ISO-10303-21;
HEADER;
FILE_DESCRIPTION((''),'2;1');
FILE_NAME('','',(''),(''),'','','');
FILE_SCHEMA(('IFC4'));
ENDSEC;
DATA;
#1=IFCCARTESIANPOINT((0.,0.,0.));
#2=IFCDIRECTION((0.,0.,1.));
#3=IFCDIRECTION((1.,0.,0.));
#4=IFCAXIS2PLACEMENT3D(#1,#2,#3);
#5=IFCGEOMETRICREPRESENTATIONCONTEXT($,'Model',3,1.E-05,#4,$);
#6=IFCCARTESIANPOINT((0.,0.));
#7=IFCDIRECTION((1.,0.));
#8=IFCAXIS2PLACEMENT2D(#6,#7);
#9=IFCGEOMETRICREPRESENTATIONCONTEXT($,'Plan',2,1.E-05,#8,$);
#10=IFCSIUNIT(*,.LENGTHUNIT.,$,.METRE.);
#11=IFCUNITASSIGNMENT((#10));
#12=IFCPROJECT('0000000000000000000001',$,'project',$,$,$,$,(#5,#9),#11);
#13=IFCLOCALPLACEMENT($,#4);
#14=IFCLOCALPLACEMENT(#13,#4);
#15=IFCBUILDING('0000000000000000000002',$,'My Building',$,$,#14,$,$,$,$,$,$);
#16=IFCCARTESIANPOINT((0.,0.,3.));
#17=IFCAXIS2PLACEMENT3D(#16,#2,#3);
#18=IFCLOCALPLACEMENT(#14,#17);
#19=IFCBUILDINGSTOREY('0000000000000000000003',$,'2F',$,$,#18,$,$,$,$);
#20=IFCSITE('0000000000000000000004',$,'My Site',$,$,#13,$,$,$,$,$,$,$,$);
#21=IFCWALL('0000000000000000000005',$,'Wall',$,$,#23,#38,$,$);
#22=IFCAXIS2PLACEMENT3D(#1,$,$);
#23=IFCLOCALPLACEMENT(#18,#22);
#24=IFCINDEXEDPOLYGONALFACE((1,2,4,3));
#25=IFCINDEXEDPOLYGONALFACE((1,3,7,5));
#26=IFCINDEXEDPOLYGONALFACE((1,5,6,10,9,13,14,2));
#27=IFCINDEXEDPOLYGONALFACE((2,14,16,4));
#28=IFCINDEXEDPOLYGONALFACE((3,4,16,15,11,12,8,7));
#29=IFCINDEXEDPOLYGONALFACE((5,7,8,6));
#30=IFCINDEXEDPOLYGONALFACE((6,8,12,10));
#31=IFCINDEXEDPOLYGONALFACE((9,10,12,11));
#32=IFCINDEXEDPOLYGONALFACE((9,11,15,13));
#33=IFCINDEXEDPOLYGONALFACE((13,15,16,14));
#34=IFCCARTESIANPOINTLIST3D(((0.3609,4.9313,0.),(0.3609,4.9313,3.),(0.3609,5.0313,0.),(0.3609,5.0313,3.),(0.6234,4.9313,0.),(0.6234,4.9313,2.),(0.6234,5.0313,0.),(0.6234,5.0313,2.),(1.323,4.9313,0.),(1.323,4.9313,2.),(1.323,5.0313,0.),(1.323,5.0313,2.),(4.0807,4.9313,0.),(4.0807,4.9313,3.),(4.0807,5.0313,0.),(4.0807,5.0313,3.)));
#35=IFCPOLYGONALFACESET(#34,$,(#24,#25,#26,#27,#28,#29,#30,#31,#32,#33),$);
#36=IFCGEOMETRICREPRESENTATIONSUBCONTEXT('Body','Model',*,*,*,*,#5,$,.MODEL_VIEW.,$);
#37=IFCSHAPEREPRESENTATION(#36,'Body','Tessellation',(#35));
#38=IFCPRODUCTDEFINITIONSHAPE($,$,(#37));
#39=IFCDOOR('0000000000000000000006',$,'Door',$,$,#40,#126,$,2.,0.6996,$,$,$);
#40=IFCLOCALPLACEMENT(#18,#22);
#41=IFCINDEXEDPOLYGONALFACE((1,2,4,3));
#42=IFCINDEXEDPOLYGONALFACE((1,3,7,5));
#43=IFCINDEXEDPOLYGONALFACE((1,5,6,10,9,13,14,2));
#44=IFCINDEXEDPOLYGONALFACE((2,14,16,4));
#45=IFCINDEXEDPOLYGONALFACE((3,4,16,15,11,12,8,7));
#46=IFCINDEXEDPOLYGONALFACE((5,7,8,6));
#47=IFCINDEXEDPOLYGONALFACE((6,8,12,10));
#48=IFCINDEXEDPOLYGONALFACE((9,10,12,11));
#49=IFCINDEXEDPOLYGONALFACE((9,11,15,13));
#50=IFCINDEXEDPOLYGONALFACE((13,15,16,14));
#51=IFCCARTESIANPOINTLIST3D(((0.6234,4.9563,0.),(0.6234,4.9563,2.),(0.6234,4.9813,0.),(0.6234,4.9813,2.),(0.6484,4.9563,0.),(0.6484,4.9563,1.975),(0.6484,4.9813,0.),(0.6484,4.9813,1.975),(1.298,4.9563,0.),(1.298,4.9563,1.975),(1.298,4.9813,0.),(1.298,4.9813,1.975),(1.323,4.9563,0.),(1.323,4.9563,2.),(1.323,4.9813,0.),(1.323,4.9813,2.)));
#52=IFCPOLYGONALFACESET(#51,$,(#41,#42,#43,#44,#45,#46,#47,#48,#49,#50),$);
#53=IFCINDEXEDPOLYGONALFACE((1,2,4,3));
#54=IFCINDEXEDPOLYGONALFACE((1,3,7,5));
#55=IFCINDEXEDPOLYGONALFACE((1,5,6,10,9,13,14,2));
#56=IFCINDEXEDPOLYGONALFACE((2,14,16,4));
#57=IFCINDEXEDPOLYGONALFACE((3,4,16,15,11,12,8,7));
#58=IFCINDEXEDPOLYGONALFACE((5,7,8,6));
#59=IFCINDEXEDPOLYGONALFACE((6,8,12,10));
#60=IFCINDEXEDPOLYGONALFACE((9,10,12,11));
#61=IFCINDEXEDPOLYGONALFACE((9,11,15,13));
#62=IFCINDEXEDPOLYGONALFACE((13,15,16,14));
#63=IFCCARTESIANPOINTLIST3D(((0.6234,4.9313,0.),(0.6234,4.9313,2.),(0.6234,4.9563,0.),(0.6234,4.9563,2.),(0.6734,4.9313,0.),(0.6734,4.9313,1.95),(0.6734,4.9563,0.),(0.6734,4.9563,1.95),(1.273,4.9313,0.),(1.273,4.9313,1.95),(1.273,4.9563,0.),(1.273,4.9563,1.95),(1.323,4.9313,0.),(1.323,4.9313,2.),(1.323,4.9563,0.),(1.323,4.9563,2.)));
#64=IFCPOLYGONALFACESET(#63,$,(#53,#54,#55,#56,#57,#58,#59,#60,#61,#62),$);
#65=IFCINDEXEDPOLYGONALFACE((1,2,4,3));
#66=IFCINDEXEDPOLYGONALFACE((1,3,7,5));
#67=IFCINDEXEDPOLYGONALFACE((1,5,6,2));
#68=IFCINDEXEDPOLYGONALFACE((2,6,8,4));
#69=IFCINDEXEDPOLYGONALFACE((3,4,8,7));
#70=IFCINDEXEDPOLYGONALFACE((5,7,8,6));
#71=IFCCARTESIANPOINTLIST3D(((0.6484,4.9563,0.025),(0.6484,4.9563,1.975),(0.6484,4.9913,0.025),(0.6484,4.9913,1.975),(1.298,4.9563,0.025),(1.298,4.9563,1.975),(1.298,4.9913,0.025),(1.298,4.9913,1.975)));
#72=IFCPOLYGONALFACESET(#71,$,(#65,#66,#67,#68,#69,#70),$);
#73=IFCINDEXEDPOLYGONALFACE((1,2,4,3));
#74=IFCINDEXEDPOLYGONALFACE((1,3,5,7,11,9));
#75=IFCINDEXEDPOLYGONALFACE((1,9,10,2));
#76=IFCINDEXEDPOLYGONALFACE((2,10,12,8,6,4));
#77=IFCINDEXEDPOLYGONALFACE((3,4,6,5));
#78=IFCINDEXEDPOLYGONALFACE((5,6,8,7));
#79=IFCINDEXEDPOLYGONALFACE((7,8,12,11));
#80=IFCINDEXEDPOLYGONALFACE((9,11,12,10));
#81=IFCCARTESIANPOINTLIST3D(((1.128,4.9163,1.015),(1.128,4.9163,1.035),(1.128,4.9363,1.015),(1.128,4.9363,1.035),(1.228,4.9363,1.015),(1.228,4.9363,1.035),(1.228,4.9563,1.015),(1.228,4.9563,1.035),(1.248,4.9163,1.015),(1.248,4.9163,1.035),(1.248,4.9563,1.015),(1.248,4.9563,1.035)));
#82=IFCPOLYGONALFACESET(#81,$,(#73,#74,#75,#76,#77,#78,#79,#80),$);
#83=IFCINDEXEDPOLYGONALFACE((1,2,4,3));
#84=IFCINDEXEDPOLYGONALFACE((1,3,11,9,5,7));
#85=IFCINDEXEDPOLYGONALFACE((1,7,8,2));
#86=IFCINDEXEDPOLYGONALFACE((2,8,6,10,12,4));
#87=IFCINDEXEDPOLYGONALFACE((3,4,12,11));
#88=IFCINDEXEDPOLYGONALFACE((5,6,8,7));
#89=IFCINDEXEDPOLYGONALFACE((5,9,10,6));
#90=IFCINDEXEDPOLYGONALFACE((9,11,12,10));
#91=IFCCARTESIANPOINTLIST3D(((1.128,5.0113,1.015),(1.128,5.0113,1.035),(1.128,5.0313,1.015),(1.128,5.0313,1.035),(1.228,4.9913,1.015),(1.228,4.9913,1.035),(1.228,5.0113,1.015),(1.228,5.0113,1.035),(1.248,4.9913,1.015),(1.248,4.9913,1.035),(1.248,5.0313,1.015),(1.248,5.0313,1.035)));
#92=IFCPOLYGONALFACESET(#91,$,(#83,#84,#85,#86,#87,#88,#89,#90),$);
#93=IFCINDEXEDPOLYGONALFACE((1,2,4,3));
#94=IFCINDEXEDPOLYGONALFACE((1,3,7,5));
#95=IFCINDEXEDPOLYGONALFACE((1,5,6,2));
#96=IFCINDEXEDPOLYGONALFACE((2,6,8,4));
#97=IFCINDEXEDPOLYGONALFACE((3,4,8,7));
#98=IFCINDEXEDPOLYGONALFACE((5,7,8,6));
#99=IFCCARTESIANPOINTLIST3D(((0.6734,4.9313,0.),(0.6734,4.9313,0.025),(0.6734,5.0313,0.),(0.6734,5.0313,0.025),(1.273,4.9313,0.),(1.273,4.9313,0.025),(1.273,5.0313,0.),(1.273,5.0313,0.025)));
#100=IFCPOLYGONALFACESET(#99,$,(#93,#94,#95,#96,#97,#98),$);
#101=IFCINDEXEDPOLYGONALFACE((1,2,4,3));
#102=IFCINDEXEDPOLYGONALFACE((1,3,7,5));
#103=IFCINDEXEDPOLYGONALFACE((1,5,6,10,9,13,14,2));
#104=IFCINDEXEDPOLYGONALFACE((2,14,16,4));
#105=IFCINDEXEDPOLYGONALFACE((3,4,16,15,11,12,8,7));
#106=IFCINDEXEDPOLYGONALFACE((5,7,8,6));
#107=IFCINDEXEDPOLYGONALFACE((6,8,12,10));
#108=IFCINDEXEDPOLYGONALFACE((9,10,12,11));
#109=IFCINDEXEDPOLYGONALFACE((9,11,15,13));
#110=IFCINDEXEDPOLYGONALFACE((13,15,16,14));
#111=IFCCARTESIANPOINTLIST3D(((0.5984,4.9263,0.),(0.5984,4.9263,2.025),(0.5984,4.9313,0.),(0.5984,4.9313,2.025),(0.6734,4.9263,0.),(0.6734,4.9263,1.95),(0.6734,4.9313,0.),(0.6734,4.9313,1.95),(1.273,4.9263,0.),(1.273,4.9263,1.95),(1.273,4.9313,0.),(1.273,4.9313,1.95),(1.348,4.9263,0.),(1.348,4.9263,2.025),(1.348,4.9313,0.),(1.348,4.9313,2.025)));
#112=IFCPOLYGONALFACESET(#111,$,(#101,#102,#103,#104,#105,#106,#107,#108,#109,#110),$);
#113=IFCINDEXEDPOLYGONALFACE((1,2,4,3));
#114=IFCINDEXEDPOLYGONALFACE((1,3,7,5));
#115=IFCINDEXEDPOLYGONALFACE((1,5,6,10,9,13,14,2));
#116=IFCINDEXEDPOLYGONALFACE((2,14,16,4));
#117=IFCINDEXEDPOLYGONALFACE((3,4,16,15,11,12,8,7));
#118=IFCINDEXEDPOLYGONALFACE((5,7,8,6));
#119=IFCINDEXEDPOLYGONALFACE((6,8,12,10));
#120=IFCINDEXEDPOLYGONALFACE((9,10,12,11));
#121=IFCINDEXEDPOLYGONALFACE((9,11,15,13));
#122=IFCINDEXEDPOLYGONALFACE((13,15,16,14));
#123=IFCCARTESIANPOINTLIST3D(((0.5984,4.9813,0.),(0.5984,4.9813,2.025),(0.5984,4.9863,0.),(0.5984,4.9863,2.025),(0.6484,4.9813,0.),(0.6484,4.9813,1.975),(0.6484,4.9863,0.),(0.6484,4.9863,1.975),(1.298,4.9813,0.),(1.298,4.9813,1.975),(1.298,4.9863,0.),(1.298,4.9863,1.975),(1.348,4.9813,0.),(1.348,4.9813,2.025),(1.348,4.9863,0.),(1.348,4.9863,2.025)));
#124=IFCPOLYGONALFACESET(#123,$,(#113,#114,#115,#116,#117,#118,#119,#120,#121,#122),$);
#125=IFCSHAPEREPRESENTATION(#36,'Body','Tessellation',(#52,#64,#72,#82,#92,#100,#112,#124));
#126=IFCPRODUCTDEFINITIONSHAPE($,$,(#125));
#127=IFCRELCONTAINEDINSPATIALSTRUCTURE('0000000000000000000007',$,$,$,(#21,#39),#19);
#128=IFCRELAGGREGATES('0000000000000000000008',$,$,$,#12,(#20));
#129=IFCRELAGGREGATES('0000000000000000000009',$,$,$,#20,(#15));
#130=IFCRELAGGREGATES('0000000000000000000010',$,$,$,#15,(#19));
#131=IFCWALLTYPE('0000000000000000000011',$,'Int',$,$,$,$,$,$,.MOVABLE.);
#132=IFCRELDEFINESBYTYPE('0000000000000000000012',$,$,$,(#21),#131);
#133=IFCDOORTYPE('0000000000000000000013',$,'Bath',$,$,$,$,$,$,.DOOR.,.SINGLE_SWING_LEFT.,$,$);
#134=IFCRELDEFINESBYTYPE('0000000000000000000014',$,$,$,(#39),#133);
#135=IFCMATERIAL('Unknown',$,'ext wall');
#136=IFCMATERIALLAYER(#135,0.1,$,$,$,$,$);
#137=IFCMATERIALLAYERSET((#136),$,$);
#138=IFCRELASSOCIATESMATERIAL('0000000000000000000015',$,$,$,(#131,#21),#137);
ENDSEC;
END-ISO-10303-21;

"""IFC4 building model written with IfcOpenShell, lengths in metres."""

from ifc_helpers import new_model, entity, si_unit, frame, origin_with_axes, origin_2d_with_axis, place, context, subcontext, project, spatial, line, indexed_curve, outline, extrude, shape, source, transform, mapped, material, layer, layer_set, layer_usage, type_object, type_shapes, element, fill, save


model = new_model("IFC4")

# Units and contexts
model_context = context("Model", 3, precision=1e-05, world=origin_with_axes())
plan_context = context("Plan", 2, precision=1e-05, world=origin_2d_with_axis())
body_context_1 = subcontext(model_context, "Body", "Model", "MODEL_VIEW")
body_context_2 = subcontext(plan_context, "Body", "Plan", "PLAN_VIEW")
ifc_project = project(units=[si_unit("LENGTHUNIT", "METRE")], contexts=[model_context, plan_context])

# Site, building, storey
site_placement = place(None, origin_with_axes())
site = spatial("IfcSite", under=ifc_project, at=site_placement, Name="My Site")
building_placement = place(site_placement, origin_with_axes())
building = spatial("IfcBuilding", under=site, at=building_placement, Name="My Building")
storey_placement = place(building_placement, frame((0.0, 0.0, 3.0), z_axis=(0.0, 0.0, 1.0), x_axis=(1.0, 0.0, 0.0)))
storey = spatial("IfcBuildingStorey", under=building, at=storey_placement, Name="2F")

# Shared definitions
ifc_material = material(Name="Unknown", Category="ext wall")

# Wall, opening, door
ifc_layer_1 = layer(ifc_material, 0.1)
ifc_layer_set_1 = layer_set([ifc_layer_1])
wall_type_1 = type_object("IfcWallType", Name="Int", PredefinedType="MOVABLE", material=ifc_layer_set_1)
ifc_layer_usage_1 = layer_usage(ifc_layer_set_1, "AXIS2", "POSITIVE", 0.0)
wall_1_placement = place(storey_placement, frame((4.0807, 5.0313, 0.0), z_axis=(0.0, 0.0, 1.0), x_axis=(-1.0, 0.0, 0.0)))
wall_1 = element("IfcWall", 1, at=wall_1_placement, inside=storey, type_object=wall_type_1, material=ifc_layer_usage_1, Name="Wall", context=body_context_1, shape_type="SweptSolid", body=[
    extrude(outline(indexed_curve([(0.0, 0.0), (0.0, 0.1), (3.7198, 0.1), (3.7198, 0.0)], segments=[line(1, 2, 3, 4, 1)])), origin_with_axes(), (0.0, 0.0, 1.0), 3.0),
])
shared_shape_1 = source(origin_with_axes(), body_context_1, "Body", "SweptSolid", [
    extrude(outline(indexed_curve([(0.0, 0.0), (0.6996, 0.0), (0.6996, 2.0), (0.0, 2.0)], segments=[line(1, 2, 3, 4, 1)])), frame((0.0, -0.6, 0.0), z_axis=(0.0, -1.0, 0.0), x_axis=(1.0, 0.0, 0.0)), (0.0, 0.0, -1.0), 1.2),
])
opening_1_placement = place(wall_1_placement, frame((3.4573, 0.1, 0.0), z_axis=(0.0, 0.0, 1.0), x_axis=(-1.0, 0.0, 0.0)))
opening_1 = element("IfcOpeningElement", 2, at=opening_1_placement, cuts=wall_1, PredefinedType="OPENING", context=body_context_1, shape_type="MappedRepresentation", body=[
    mapped(shared_shape_1, transform((0.0, 0.0, 0.0), x_axis=(1.0, 0.0, 0.0), y_axis=(0.0, 1.0, 0.0), z_axis=(0.0, 0.0, 1.0), scale=1.0)),
])
door_type_1 = type_object("IfcDoorType", Name="Bath", OperationType="SINGLE_SWING_LEFT", PredefinedType="DOOR")
shared_shape_2 = source(origin_with_axes(), body_context_1, "Body", "SweptSolid", [
    extrude(outline(indexed_curve([(0.0, 0.0), (0.0, 2.0), (0.6996, 2.0), (0.6996, 0.0), (0.6746, 0.0), (0.6746, 1.975), (0.025, 1.975), (0.025, 0.0)], segments=[line(1, 2, 3, 4, 5, 6, 7, 8, 1)])), frame((0.0, 0.025, 0.0), z_axis=(0.0, -1.0, 0.0), x_axis=(1.0, 0.0, 0.0)), (0.0, 0.0, -1.0), 0.025),
    extrude(outline(indexed_curve([(0.0, 0.0), (0.0, 2.0), (0.6996, 2.0), (0.6996, 0.0), (0.6496, 0.0), (0.6496, 1.95), (0.05, 1.95), (0.05, 0.0)], segments=[line(1, 2, 3, 4, 5, 6, 7, 8, 1)])), frame((0.0, 0.0, 0.0), z_axis=(0.0, -1.0, 0.0), x_axis=(1.0, 0.0, 0.0)), (0.0, 0.0, -1.0), 0.025),
    extrude(outline(indexed_curve([(0.0, 0.0), (0.6496, 0.0), (0.6496, 0.035), (0.0, 0.035)], segments=[line(1, 2, 3, 4, 1)])), frame((0.025, 0.025, 0.025), z_axis=(0.0, 0.0, 1.0), x_axis=(1.0, 0.0, 0.0)), (0.0, 0.0, 1.0), 1.95),
    extrude(outline(indexed_curve([(0.0, 0.0), (0.0, -0.04), (-0.12, -0.04), (-0.12, -0.02), (-0.02, -0.02), (-0.02, 0.0)], segments=[line(1, 2, 3, 4, 5, 6, 1)])), frame((0.6246, 0.025, 1.015), z_axis=(0.0, 0.0, 1.0), x_axis=(1.0, 0.0, 0.0)), (0.0, 0.0, 1.0), 0.02),
    extrude(outline(indexed_curve([(0.0, 0.0), (0.0, 0.04), (-0.12, 0.04), (-0.12, 0.02), (-0.02, 0.02), (-0.02, 0.0)], segments=[line(1, 2, 3, 4, 5, 6, 1)])), frame((0.6246, 0.06, 1.015), z_axis=(0.0, 0.0, 1.0), x_axis=(1.0, 0.0, 0.0)), (0.0, 0.0, 1.0), 0.02),
    extrude(outline(indexed_curve([(0.0, 0.0), (0.5996, 0.0), (0.5996, 0.1), (0.0, 0.1)], segments=[line(1, 2, 3, 4, 1)])), frame((0.05, 0.0, 0.0), z_axis=(0.0, 0.0, 1.0), x_axis=(1.0, 0.0, 0.0)), (0.0, 0.0, 1.0), 0.025),
    extrude(outline(indexed_curve([(0.0, 0.0), (0.0, 2.025), (0.7496, 2.025), (0.7496, 0.0), (0.6746, 0.0), (0.6746, 1.95), (0.075, 1.95), (0.075, 0.0)], segments=[line(1, 2, 3, 4, 5, 6, 7, 8, 1)])), frame((-0.025, -0.005, 0.0), z_axis=(0.0, -1.0, 0.0), x_axis=(1.0, 0.0, 0.0)), (0.0, 0.0, -1.0), 0.005),
    extrude(outline(indexed_curve([(0.0, 0.0), (0.0, 2.025), (0.7496, 2.025), (0.7496, 0.0), (0.6996, 0.0), (0.6996, 1.975), (0.05, 1.975), (0.05, 0.0)], segments=[line(1, 2, 3, 4, 5, 6, 7, 8, 1)])), frame((-0.025, 0.05, 0.0), z_axis=(0.0, -1.0, 0.0), x_axis=(1.0, 0.0, 0.0)), (0.0, 0.0, -1.0), 0.005),
])
shared_shape_3 = source(origin_with_axes(), body_context_2, "Body", "Curve2D", [
    entity("IfcIndexedPolyCurve", entity("IfcCartesianPointList2D", [[0.0, 0.0], [0.0, 0.05], [0.025, 0.05], [0.025, 0.025], [0.05, 0.025], [0.05, 0.0]]), [entity("IfcLineIndex", [1, 2, 3, 4, 5, 6, 1])]),
    entity("IfcIndexedPolyCurve", entity("IfcCartesianPointList2D", [[0.6996, 0.0], [0.6996, 0.05], [0.6746, 0.05], [0.6746, 0.025], [0.6496, 0.025], [0.6496, 0.0]]), [entity("IfcLineIndex", [1, 2, 3, 4, 5, 6, 1])]),
    entity("IfcTrimmedCurve", entity("IfcEllipse", entity("IfcAxis2Placement2D", entity("IfcCartesianPoint", [0.06, 0.05]), entity("IfcDirection", [1.0, 0.0])), 0.6146, 0.6496), [entity("IfcCartesianPoint", [0.6746, 0.05])], [entity("IfcCartesianPoint", [0.06, 0.6996])], True, "CARTESIAN"),
    entity("IfcIndexedPolyCurve", entity("IfcCartesianPointList2D", [[0.025, 0.05], [0.06, 0.05], [0.06, 0.6996], [0.025, 0.6996]]), [entity("IfcLineIndex", [1, 2, 3, 4, 1])]),
])
type_shapes(door_type_1, [shared_shape_2, shared_shape_3])
door_1_placement = place(opening_1_placement, frame((0.0, 0.0, 0.0), z_axis=(0.0, 0.0, 1.0), x_axis=(1.0, 0.0, 0.0)))
door_1 = element("IfcDoor", 3, at=door_1_placement, inside=storey, type_object=door_type_1, Name="Door", OverallHeight=2.0, OverallWidth=0.6996, shapes=[
    shape(body_context_1, "Body", "MappedRepresentation", [mapped(shared_shape_2, transform((0.0, 0.0, 0.0), x_axis=(1.0, 0.0, 0.0), y_axis=(0.0, 1.0, 0.0), z_axis=(0.0, 0.0, 1.0), scale=1.0))]),
    shape(body_context_2, "Body", "MappedRepresentation", [mapped(shared_shape_3, transform((0.0, 0.0, 0.0), x_axis=(1.0, 0.0, 0.0), y_axis=(0.0, 1.0, 0.0), z_axis=(0.0, 0.0, 1.0), scale=1.0))]),
])
fill(opening_1, door_1)

save(model, "model.ifc")
